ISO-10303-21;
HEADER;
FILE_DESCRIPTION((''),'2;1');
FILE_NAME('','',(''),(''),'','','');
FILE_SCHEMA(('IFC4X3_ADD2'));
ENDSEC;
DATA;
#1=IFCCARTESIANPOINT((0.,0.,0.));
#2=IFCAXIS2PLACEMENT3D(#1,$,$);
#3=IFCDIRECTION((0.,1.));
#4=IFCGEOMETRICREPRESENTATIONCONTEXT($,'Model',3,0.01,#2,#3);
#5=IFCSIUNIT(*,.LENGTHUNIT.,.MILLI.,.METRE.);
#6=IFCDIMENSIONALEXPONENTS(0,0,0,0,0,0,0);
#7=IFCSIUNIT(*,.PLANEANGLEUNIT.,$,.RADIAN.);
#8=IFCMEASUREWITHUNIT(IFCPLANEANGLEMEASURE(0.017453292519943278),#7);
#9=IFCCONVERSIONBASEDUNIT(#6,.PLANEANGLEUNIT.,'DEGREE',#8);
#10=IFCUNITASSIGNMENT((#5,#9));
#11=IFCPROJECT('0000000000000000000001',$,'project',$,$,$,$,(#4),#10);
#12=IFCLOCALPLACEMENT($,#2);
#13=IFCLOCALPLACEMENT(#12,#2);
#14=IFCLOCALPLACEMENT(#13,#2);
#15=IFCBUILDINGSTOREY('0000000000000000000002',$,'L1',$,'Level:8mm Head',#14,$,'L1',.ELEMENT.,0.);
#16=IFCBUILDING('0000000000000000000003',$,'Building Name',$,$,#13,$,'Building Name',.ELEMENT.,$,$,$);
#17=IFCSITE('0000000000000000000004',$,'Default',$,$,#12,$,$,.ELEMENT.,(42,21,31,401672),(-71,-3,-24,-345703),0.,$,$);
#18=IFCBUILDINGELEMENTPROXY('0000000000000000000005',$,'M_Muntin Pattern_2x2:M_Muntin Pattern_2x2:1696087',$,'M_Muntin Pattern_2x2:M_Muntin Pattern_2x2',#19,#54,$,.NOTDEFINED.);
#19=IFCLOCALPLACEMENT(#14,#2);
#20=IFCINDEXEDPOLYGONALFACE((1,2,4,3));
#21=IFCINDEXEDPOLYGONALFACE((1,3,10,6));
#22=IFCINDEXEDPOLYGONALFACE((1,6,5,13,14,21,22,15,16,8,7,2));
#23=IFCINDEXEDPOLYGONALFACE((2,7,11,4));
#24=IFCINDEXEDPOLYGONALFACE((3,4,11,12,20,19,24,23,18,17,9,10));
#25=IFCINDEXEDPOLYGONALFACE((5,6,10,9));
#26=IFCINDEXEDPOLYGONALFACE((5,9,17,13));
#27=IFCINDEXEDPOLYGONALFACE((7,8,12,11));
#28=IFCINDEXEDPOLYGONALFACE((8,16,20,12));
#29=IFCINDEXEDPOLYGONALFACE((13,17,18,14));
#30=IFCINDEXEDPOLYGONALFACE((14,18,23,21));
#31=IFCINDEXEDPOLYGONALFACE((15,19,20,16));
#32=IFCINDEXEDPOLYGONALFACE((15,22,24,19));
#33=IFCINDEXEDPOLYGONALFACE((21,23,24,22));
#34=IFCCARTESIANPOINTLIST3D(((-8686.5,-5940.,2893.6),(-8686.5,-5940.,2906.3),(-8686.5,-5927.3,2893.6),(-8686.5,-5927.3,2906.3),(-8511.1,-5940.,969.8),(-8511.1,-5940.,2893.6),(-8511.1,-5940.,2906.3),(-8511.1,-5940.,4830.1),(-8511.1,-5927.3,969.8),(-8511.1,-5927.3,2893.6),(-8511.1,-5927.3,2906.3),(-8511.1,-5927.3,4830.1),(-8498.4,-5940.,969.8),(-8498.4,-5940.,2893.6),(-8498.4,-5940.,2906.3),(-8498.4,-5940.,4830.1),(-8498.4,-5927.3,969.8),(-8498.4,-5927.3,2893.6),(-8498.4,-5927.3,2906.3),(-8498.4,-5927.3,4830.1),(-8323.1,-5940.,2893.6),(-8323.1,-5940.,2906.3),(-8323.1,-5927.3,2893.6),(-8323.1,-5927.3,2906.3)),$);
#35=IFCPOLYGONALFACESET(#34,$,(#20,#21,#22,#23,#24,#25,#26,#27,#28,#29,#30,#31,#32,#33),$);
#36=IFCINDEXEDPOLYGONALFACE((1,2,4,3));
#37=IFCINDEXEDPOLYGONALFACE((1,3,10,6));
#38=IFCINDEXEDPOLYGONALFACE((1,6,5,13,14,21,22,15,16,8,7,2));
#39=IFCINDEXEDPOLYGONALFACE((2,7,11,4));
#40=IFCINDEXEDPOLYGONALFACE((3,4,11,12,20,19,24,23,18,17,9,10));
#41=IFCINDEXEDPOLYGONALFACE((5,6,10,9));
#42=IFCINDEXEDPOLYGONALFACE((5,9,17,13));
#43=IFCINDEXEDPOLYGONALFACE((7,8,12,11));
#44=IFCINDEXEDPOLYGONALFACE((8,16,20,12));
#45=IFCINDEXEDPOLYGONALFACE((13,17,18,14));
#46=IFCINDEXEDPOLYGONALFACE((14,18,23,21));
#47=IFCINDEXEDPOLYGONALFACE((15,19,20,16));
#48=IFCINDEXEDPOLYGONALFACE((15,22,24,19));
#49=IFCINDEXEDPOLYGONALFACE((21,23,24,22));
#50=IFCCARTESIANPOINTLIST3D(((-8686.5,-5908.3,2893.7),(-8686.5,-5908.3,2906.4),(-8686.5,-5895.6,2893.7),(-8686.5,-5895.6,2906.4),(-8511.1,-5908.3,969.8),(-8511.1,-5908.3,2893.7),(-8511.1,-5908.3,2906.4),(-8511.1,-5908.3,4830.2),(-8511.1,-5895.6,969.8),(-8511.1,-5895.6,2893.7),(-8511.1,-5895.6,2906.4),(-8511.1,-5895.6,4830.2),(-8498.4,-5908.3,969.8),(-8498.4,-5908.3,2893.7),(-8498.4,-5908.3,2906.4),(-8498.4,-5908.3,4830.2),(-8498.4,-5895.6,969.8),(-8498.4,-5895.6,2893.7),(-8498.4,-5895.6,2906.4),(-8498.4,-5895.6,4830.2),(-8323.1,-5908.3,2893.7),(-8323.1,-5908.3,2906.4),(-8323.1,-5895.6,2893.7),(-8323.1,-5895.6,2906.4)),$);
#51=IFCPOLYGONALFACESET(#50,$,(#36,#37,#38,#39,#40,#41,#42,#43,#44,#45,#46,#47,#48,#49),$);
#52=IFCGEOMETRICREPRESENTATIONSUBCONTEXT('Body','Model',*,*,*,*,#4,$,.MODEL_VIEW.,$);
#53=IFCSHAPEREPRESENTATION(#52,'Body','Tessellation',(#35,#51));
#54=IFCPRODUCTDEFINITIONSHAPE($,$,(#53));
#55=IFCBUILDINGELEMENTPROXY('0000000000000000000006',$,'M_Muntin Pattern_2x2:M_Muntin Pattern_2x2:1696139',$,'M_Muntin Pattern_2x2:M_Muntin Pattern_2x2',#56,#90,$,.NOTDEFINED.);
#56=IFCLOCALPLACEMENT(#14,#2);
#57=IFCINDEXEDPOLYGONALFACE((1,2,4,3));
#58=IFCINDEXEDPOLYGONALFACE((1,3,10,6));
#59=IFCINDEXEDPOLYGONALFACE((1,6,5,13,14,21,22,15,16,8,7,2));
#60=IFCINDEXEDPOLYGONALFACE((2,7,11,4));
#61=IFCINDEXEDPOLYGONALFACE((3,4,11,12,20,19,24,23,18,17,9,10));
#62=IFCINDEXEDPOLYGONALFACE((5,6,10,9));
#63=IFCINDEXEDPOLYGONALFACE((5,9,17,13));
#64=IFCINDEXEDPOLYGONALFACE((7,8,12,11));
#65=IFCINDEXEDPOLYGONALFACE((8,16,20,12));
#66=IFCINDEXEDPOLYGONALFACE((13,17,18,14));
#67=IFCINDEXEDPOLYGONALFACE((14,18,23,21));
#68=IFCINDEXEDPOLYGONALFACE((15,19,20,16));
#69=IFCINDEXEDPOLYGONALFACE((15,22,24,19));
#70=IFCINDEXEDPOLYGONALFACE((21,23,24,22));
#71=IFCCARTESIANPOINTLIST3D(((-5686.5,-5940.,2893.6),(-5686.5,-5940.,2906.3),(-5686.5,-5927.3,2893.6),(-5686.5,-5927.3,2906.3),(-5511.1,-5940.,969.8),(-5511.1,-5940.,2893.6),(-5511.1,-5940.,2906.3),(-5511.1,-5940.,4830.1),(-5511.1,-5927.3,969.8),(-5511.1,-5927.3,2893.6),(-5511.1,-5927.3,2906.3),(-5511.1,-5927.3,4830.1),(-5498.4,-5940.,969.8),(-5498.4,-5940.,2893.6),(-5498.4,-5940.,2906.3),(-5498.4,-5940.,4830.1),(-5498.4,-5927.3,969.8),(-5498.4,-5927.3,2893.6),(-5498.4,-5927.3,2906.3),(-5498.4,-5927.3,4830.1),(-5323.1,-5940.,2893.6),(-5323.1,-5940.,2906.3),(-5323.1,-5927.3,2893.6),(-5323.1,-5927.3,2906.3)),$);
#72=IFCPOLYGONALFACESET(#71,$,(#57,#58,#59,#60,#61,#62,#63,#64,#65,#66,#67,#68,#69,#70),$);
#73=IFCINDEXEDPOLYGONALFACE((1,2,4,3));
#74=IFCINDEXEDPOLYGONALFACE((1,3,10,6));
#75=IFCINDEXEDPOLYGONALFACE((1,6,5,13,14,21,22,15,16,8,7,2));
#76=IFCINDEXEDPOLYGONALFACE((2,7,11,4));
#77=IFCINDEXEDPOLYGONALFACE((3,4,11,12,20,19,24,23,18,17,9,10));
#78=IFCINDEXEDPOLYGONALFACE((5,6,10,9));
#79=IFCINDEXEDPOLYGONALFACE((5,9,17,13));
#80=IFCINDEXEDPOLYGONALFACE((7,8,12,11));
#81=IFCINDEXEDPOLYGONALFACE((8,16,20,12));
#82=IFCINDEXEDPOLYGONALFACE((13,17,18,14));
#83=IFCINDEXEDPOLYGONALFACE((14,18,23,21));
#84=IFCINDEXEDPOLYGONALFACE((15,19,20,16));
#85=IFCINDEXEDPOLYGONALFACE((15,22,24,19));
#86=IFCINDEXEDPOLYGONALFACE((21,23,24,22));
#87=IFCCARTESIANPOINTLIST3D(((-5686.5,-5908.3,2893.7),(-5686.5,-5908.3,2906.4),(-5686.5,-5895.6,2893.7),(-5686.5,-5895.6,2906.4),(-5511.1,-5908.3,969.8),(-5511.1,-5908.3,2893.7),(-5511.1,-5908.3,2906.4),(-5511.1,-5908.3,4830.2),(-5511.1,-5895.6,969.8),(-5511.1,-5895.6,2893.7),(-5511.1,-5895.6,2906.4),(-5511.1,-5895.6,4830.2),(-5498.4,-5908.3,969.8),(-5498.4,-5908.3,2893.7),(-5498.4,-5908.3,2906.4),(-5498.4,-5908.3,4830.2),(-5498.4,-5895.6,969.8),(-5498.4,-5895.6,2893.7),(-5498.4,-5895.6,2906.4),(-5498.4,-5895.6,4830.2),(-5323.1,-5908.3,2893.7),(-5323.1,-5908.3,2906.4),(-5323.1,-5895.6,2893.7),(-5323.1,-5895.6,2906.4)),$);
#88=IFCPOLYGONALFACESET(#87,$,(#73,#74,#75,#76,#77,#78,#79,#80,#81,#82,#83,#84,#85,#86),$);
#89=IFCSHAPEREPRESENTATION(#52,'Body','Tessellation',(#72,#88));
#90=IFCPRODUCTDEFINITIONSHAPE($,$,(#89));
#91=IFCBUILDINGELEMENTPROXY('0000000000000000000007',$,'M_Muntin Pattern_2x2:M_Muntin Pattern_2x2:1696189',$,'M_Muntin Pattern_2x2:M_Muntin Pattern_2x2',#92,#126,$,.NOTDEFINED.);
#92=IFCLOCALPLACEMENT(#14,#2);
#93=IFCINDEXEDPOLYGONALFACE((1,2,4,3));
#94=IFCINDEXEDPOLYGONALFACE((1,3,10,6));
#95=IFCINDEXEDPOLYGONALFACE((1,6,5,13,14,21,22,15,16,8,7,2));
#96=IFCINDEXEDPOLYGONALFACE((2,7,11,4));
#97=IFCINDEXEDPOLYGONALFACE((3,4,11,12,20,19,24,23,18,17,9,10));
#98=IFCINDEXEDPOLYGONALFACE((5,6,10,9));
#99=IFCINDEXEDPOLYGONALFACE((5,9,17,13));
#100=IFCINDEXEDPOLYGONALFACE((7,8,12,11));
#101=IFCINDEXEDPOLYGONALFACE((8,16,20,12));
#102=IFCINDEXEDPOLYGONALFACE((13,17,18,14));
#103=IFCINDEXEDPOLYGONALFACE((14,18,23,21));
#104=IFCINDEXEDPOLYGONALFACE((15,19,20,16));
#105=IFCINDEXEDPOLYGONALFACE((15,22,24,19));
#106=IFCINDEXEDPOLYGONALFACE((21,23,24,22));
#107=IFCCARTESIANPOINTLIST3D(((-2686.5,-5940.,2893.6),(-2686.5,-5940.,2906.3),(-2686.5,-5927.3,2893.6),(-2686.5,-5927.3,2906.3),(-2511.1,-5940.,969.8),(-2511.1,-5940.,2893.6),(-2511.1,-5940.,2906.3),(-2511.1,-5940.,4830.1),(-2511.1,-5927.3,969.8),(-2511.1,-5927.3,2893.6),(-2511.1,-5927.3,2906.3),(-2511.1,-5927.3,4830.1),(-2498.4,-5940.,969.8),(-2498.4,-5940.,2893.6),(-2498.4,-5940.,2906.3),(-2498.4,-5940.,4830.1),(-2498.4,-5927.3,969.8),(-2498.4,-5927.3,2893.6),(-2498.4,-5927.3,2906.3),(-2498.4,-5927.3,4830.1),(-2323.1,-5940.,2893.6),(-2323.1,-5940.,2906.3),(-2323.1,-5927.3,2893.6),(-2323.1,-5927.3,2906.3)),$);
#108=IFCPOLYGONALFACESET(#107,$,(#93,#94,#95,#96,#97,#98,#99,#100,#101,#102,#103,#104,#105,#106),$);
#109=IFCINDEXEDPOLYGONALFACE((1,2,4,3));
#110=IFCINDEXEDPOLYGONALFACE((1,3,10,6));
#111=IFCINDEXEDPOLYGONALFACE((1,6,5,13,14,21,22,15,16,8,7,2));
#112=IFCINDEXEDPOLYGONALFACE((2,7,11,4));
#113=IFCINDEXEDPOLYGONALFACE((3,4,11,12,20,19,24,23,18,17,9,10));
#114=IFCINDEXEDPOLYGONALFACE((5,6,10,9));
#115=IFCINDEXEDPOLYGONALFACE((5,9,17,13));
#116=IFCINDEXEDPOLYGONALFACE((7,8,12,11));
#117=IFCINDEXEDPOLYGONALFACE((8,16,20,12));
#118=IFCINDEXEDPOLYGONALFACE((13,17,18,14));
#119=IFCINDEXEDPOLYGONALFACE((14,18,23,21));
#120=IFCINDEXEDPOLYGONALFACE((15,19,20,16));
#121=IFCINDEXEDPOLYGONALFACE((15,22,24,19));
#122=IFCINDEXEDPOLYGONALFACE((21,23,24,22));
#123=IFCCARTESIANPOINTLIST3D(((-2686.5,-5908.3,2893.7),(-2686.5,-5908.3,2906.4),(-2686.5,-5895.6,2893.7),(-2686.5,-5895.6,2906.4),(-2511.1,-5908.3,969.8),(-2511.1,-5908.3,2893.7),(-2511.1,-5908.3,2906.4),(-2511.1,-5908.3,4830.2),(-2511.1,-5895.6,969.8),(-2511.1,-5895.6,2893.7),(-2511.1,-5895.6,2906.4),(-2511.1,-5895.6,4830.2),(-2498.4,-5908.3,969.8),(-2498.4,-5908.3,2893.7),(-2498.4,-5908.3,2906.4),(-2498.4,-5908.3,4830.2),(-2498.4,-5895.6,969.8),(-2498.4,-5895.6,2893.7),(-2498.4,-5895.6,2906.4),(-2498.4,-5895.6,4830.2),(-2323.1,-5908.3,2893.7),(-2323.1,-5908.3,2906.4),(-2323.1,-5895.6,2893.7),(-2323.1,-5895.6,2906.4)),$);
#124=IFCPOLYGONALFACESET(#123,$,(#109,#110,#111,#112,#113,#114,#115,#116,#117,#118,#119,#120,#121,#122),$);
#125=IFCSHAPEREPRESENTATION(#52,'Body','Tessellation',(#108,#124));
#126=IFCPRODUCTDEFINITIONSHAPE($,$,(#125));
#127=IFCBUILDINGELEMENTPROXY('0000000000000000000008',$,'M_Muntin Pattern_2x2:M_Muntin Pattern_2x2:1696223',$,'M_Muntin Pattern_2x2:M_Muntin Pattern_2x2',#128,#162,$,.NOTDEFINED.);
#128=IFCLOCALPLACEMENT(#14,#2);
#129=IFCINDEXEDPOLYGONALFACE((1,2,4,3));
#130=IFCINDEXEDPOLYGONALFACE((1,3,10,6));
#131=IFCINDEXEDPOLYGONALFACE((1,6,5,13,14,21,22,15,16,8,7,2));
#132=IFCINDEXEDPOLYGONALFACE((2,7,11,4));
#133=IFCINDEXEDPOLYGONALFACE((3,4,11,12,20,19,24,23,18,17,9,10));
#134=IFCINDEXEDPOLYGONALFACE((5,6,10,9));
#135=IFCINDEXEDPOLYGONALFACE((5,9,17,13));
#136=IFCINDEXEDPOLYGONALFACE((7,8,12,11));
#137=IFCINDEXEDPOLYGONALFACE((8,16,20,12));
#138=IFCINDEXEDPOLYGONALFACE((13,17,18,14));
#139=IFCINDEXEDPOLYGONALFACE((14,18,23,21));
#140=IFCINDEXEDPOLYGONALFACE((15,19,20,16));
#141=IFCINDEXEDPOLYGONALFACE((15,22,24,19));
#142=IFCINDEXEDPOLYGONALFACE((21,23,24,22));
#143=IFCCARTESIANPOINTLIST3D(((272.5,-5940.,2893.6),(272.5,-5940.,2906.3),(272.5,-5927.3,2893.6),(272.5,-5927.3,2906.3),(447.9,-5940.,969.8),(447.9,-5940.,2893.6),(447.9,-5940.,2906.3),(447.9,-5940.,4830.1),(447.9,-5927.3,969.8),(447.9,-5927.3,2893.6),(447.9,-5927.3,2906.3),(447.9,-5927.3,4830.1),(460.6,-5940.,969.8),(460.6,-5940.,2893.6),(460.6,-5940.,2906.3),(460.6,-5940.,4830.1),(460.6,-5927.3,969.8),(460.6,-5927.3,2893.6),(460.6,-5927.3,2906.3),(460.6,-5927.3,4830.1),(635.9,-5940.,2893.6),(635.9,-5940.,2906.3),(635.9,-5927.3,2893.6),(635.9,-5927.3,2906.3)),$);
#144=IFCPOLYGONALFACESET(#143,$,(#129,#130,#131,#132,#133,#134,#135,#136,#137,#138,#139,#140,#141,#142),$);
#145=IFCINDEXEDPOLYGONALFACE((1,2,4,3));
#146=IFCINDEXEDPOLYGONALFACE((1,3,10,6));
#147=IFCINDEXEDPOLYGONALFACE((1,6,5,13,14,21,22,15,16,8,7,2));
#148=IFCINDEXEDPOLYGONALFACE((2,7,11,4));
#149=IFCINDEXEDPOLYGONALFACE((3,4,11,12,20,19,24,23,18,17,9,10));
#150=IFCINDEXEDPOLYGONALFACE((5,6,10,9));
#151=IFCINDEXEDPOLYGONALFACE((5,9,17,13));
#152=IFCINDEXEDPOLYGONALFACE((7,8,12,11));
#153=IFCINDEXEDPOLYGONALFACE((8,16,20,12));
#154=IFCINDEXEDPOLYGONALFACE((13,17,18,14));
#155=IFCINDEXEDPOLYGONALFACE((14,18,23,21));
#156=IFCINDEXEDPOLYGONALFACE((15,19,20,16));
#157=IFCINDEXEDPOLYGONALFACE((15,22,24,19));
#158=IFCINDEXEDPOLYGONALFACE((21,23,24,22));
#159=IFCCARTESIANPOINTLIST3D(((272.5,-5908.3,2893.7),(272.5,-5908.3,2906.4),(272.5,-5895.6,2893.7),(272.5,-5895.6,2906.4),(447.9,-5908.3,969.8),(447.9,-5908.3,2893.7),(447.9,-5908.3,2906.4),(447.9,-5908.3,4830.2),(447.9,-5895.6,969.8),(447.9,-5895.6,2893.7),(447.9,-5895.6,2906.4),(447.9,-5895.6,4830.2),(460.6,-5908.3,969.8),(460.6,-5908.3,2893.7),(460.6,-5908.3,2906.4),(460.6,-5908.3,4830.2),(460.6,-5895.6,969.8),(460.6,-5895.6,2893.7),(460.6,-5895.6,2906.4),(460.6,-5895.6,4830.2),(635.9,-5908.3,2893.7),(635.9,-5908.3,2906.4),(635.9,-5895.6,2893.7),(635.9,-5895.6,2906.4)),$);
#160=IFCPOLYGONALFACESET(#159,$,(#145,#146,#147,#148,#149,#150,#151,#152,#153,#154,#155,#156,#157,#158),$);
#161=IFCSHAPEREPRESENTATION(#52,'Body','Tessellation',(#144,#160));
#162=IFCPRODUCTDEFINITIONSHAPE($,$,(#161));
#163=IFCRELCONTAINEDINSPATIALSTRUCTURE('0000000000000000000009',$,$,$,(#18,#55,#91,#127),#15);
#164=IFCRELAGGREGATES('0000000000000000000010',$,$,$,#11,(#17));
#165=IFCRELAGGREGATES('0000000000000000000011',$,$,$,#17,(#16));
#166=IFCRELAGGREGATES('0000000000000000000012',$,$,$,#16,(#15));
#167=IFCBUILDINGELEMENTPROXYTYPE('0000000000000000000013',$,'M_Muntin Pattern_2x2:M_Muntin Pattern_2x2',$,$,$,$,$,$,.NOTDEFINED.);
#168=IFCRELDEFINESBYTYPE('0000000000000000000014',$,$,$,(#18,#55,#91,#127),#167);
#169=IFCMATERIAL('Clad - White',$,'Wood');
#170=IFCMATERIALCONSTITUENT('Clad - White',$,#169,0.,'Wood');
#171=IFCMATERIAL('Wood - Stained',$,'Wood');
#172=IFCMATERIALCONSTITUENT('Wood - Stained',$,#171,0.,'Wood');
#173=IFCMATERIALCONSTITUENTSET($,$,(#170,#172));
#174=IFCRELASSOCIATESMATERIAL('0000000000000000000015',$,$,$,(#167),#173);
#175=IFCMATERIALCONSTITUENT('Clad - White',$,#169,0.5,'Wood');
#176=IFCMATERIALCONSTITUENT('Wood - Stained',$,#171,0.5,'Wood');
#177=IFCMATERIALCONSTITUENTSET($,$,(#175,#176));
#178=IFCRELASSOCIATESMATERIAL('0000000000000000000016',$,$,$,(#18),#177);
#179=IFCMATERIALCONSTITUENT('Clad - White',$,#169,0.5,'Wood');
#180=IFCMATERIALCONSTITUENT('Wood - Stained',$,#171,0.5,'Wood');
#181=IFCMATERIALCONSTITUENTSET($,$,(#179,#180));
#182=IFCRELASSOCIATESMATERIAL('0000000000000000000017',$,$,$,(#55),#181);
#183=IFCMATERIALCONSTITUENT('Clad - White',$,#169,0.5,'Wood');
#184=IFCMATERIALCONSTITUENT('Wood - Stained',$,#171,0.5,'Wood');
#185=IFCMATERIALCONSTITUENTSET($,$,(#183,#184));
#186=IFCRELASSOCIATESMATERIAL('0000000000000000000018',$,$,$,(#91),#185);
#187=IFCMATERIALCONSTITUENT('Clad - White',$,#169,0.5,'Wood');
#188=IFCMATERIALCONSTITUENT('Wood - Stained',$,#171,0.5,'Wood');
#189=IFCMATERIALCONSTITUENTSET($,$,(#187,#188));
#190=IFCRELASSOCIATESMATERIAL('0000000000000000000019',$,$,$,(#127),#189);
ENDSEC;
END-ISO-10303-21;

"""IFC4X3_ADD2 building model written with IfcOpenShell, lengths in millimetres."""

from ifc_helpers import new_model, entity, si_unit, converted_unit, direction, frame, origin, place, context, subcontext, project, spatial, polyline, outline, extrude, source, transform, mapped, material, constituent, constituent_set, type_object, type_shapes, element, save


model = new_model("IFC4X3_ADD2")

# Units and contexts
model_context = context("Model", 3, precision=0.01, world=origin(), true_north=direction((0.0, 1.0)))
body_context = subcontext(model_context, "Body", "Model", "MODEL_VIEW")
ifc_project = project(units=[si_unit("LENGTHUNIT", "METRE", prefix="MILLI"), converted_unit("PLANEANGLEUNIT", "DEGREE", entity("IfcPlaneAngleMeasure", 0.017453292519943278), si_unit("PLANEANGLEUNIT", "RADIAN"), dimensions=[0, 0, 0, 0, 0, 0, 0])], contexts=[model_context])

# Site, building, storey
site_placement = place(None, origin())
site = spatial("IfcSite", under=ifc_project, at=site_placement, Name="Default", CompositionType="ELEMENT", RefLatitude=(42, 21, 31, 401672), RefLongitude=(-71, -3, -24, -345703), RefElevation=0.0)
building_placement = place(site_placement, origin())
building = spatial("IfcBuilding", under=site, at=building_placement, Name="Building Name", LongName="Building Name", CompositionType="ELEMENT")
storey_placement = place(building_placement, origin())
storey = spatial("IfcBuildingStorey", under=building, at=storey_placement, Name="L1", ObjectType="Level:8mm Head", LongName="L1", CompositionType="ELEMENT", Elevation=0.0)

# Building element proxies
ifc_material_1 = material(Name="Clad - White", Category="Wood")
ifc_constituent_1 = constituent(ifc_material_1, Name="Clad - White", Category="Wood", fraction=0.5)
ifc_material_2 = material(Name="Wood - Stained", Category="Wood")
ifc_constituent_2 = constituent(ifc_material_2, Name="Wood - Stained", Category="Wood", fraction=0.5)
ifc_constituent_set_1 = constituent_set(constituents=[ifc_constituent_1, ifc_constituent_2])
ifc_constituent_3 = constituent(ifc_material_1, Name="Clad - White", Category="Wood", fraction=0.0)
ifc_constituent_4 = constituent(ifc_material_2, Name="Wood - Stained", Category="Wood", fraction=0.0)
ifc_constituent_set_2 = constituent_set(constituents=[ifc_constituent_3, ifc_constituent_4])
building_element_proxy_type_1 = type_object("IfcBuildingElementProxyType", Name="M_Muntin Pattern_2x2:M_Muntin Pattern_2x2", PredefinedType="NOTDEFINED", material=ifc_constituent_set_2)
shared_shape_1 = source(origin(), body_context, "Body", "SweptSolid", [
    extrude(outline(polyline([(6.4, -6.4), (1930.1, -6.4), (1930.1, 6.3), (6.4, 6.3), (6.4, 181.7), (-6.3, 181.7), (-6.3, 6.3), (-1930.2, 6.3), (-1930.2, -6.4), (-6.3, -6.4), (-6.3, -181.7), (6.4, -181.7), (6.4, -6.4)])), frame((0.0, 9.5, 1930.1), z_axis=(0.0, 1.0, 0.0), x_axis=(0.0, 0.0, 1.0)), (0.0, 0.0, 1.0), 12.7),
    extrude(outline(polyline([(6.4, -6.4), (1930.2, -6.4), (1930.2, 6.3), (6.4, 6.3), (6.4, 181.7), (-6.3, 181.7), (-6.3, 6.3), (-1930.2, 6.3), (-1930.2, -6.4), (-6.3, -6.4), (-6.3, -181.7), (6.4, -181.7), (6.4, -6.4)])), frame((0.0, -22.2, 1930.2), z_axis=(0.0, 1.0, 0.0), x_axis=(0.0, 0.0, 1.0)), (0.0, 0.0, 1.0), 12.7),
])
type_shapes(building_element_proxy_type_1, [shared_shape_1])
proxy_1_placement = place(storey_placement, frame((-8504.8, -5917.8, 969.8), z_axis=(0.0, 0.0, 1.0), x_axis=(-1.0, 0.0, 0.0)))
element("IfcBuildingElementProxy", 1, at=proxy_1_placement, inside=storey, type_object=building_element_proxy_type_1, material=ifc_constituent_set_1, Name="M_Muntin Pattern_2x2:M_Muntin Pattern_2x2:1696087", ObjectType="M_Muntin Pattern_2x2:M_Muntin Pattern_2x2", PredefinedType="NOTDEFINED", context=body_context, shape_type="MappedRepresentation", body=[
    mapped(shared_shape_1, transform((0.0, 0.0, 0.0), scale=1.0)),
])
ifc_constituent_5 = constituent(ifc_material_1, Name="Clad - White", Category="Wood", fraction=0.5)
ifc_constituent_6 = constituent(ifc_material_2, Name="Wood - Stained", Category="Wood", fraction=0.5)
ifc_constituent_set_3 = constituent_set(constituents=[ifc_constituent_5, ifc_constituent_6])
proxy_2_placement = place(storey_placement, frame((-5504.8, -5917.8, 969.8), z_axis=(0.0, 0.0, 1.0), x_axis=(-1.0, 0.0, 0.0)))
element("IfcBuildingElementProxy", 2, at=proxy_2_placement, inside=storey, type_object=building_element_proxy_type_1, material=ifc_constituent_set_3, Name="M_Muntin Pattern_2x2:M_Muntin Pattern_2x2:1696139", ObjectType="M_Muntin Pattern_2x2:M_Muntin Pattern_2x2", PredefinedType="NOTDEFINED", context=body_context, shape_type="MappedRepresentation", body=[
    mapped(shared_shape_1, transform((0.0, 0.0, 0.0), scale=1.0)),
])
ifc_constituent_7 = constituent(ifc_material_1, Name="Clad - White", Category="Wood", fraction=0.5)
ifc_constituent_8 = constituent(ifc_material_2, Name="Wood - Stained", Category="Wood", fraction=0.5)
ifc_constituent_set_4 = constituent_set(constituents=[ifc_constituent_7, ifc_constituent_8])
proxy_3_placement = place(storey_placement, frame((-2504.8, -5917.8, 969.8), z_axis=(0.0, 0.0, 1.0), x_axis=(-1.0, 0.0, 0.0)))
element("IfcBuildingElementProxy", 3, at=proxy_3_placement, inside=storey, type_object=building_element_proxy_type_1, material=ifc_constituent_set_4, Name="M_Muntin Pattern_2x2:M_Muntin Pattern_2x2:1696189", ObjectType="M_Muntin Pattern_2x2:M_Muntin Pattern_2x2", PredefinedType="NOTDEFINED", context=body_context, shape_type="MappedRepresentation", body=[
    mapped(shared_shape_1, transform((0.0, 0.0, 0.0), scale=1.0)),
])
ifc_constituent_9 = constituent(ifc_material_1, Name="Clad - White", Category="Wood", fraction=0.5)
ifc_constituent_10 = constituent(ifc_material_2, Name="Wood - Stained", Category="Wood", fraction=0.5)
ifc_constituent_set_5 = constituent_set(constituents=[ifc_constituent_9, ifc_constituent_10])
proxy_4_placement = place(storey_placement, frame((454.2, -5917.8, 969.8), z_axis=(0.0, 0.0, 1.0), x_axis=(-1.0, 0.0, 0.0)))
element("IfcBuildingElementProxy", 4, at=proxy_4_placement, inside=storey, type_object=building_element_proxy_type_1, material=ifc_constituent_set_5, Name="M_Muntin Pattern_2x2:M_Muntin Pattern_2x2:1696223", ObjectType="M_Muntin Pattern_2x2:M_Muntin Pattern_2x2", PredefinedType="NOTDEFINED", context=body_context, shape_type="MappedRepresentation", body=[
    mapped(shared_shape_1, transform((0.0, 0.0, 0.0), scale=1.0)),
])

save(model, "model.ifc")
